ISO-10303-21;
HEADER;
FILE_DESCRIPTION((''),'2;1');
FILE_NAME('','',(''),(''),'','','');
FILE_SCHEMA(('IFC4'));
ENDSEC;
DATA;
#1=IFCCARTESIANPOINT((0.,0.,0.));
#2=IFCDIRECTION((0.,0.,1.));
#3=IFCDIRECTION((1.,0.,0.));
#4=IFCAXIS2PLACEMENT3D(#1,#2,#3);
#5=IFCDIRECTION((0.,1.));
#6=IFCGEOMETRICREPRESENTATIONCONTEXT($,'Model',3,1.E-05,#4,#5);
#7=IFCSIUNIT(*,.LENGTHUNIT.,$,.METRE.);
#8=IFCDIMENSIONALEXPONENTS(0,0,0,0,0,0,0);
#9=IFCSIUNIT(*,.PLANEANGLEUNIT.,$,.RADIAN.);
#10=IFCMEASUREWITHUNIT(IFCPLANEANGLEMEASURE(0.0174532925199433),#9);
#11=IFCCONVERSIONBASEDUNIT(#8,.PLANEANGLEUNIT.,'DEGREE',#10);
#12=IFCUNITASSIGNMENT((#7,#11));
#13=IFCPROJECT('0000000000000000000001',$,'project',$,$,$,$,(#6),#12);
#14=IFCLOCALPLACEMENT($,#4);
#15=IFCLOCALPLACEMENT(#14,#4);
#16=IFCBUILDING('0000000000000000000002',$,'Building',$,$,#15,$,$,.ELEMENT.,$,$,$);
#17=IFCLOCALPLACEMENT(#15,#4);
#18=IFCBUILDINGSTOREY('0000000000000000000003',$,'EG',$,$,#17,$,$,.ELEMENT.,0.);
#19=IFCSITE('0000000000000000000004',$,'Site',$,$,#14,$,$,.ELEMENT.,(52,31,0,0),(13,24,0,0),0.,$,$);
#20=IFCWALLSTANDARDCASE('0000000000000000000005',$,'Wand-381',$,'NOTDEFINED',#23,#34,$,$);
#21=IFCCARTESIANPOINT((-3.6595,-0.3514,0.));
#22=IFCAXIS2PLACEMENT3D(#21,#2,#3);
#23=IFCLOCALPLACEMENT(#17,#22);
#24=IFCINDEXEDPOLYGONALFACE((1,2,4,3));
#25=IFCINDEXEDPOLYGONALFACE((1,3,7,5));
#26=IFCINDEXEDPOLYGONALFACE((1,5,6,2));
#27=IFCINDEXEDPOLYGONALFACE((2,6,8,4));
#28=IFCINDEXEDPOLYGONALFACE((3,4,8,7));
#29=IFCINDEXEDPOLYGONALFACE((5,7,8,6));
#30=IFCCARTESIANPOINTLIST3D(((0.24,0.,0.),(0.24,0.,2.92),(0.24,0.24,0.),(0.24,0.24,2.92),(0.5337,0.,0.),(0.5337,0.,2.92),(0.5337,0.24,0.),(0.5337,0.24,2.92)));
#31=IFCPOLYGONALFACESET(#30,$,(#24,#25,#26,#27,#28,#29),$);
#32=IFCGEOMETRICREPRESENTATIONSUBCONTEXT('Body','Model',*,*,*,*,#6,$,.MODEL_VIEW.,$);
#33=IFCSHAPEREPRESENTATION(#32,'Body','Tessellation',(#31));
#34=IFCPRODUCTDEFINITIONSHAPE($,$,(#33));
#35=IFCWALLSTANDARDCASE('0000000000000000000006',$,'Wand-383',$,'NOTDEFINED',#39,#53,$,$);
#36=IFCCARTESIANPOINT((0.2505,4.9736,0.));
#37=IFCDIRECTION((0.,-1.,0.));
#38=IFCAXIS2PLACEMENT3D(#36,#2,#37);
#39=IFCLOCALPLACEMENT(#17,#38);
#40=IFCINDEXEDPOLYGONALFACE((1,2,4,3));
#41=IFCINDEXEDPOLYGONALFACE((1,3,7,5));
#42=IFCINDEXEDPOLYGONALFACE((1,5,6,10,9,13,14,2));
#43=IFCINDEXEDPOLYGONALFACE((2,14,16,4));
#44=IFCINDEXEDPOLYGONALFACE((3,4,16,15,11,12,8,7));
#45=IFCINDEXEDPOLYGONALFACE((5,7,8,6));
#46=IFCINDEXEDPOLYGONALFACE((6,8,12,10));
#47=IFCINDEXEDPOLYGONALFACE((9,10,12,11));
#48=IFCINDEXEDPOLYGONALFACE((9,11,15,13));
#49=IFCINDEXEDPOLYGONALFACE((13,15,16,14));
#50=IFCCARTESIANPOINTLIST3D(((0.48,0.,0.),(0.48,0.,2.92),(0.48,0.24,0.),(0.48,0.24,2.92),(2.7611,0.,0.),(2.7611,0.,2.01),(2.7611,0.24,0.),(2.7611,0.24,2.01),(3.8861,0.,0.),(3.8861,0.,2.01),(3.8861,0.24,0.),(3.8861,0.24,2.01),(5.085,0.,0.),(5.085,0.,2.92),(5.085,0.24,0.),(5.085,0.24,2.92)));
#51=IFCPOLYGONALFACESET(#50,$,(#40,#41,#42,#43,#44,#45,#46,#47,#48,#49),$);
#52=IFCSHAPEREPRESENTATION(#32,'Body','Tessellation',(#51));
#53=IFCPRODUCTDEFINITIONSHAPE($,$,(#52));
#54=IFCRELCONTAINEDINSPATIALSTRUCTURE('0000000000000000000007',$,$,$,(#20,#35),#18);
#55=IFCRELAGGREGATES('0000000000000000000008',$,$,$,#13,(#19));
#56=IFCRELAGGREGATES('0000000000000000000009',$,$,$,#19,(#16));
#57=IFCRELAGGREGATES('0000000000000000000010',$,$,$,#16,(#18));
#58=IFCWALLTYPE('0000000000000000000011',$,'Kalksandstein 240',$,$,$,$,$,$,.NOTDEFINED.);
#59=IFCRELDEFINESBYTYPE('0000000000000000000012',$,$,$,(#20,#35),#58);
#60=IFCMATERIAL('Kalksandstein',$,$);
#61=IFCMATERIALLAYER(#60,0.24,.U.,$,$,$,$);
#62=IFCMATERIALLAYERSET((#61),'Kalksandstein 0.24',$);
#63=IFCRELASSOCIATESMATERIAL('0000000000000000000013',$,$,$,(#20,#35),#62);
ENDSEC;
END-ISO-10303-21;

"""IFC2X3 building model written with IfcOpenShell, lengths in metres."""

from ifc_helpers import new_model, entity, si_unit, converted_unit, direction, frame, origin_with_axes, origin_2d_with_axis, place, context, subcontext, project, spatial, polyline, rectangle, outline, extrude, material, layer, layer_set, layer_usage, type_object, element, save


model = new_model("IFC2X3")

# Units and contexts
model_context = context("Model", 3, precision=1e-05, world=origin_with_axes(), true_north=direction((0.0, 1.0)))
body_context = subcontext(model_context, "Body", "Model", "MODEL_VIEW")
ifc_project = project(units=[si_unit("LENGTHUNIT", "METRE"), converted_unit("PLANEANGLEUNIT", "DEGREE", entity("IfcPlaneAngleMeasure", 0.0174532925199433), si_unit("PLANEANGLEUNIT", "RADIAN"), dimensions=[0, 0, 0, 0, 0, 0, 0])], contexts=[model_context])

# Site, building, storey
site_placement = place(None, origin_with_axes())
site = spatial("IfcSite", under=ifc_project, at=site_placement, Name="Site", CompositionType="ELEMENT", RefLatitude=(52, 31, 0, 0), RefLongitude=(13, 24, 0, 0), RefElevation=0.0)
building_placement = place(site_placement, origin_with_axes())
building = spatial("IfcBuilding", under=site, at=building_placement, Name="Building", CompositionType="ELEMENT")
storey_placement = place(building_placement, origin_with_axes())
storey = spatial("IfcBuildingStorey", under=building, at=storey_placement, Name="EG", CompositionType="ELEMENT", Elevation=0.0)

# Shared definitions
ifc_material_1 = material(Name="Kalksandstein")

# Shared definitions
ifc_layer_1 = layer(ifc_material_1, 0.24, ventilated="UNKNOWN")
ifc_layer_set_1 = layer_set([ifc_layer_1], Name="Kalksandstein 0.24")
wall_type_1 = type_object("IfcWallType", Name="Kalksandstein 240", PredefinedType="NOTDEFINED")

# Wall
ifc_layer_usage_1 = layer_usage(ifc_layer_set_1, "AXIS2", "POSITIVE", 0.0)
wall_1_placement = place(storey_placement, frame((-3.6595, -0.3514, 0.0), z_axis=(0.0, 0.0, 1.0), x_axis=(1.0, 0.0, 0.0)))
element("IfcWallStandardCase", 1, at=wall_1_placement, inside=storey, type_object=wall_type_1, material=ifc_layer_usage_1, Name="Wand-381", ObjectType="NOTDEFINED", context=body_context, shape_type="SweptSolid", body=[
    extrude(outline(polyline([(0.24, 0.0), (0.5337, 0.0), (0.5337, 0.24), (0.24, 0.24), (0.24, 0.0)])), origin_with_axes(), (0.0, 0.0, 1.0), 2.92),
])

# Wall, opening
ifc_layer_usage_2 = layer_usage(ifc_layer_set_1, "AXIS2", "POSITIVE", 0.0)
wall_2_placement = place(storey_placement, frame((0.2505, 4.9736, 0.0), z_axis=(0.0, 0.0, 1.0), x_axis=(0.0, -1.0, 0.0)))
wall_2 = element("IfcWallStandardCase", 2, at=wall_2_placement, inside=storey, type_object=wall_type_1, material=ifc_layer_usage_2, Name="Wand-383", ObjectType="NOTDEFINED", context=body_context, shape_type="SweptSolid", body=[
    extrude(outline(polyline([(0.48, 0.0), (5.085, 0.0), (5.085, 0.24), (0.48, 0.24), (0.48, 0.0)])), origin_with_axes(), (0.0, 0.0, 1.0), 2.92),
])
opening_1_placement = place(wall_2_placement, frame((3.3236, 0.0, 0.0), z_axis=(0.0, 0.0, 1.0), x_axis=(1.0, 0.0, 0.0)))
element("IfcOpeningElement", 3, at=opening_1_placement, cuts=wall_2, context=body_context, shape_type="SweptSolid", body=[
    extrude(rectangle(XDim=1.125, YDim=2.01, at=origin_2d_with_axis()), frame((0.0, -0.24, 1.005), z_axis=(0.0, 1.0, 0.0), x_axis=(1.0, 0.0, 0.0)), (0.0, 0.0, 1.0), 0.72),
])

save(model, "model.ifc")
